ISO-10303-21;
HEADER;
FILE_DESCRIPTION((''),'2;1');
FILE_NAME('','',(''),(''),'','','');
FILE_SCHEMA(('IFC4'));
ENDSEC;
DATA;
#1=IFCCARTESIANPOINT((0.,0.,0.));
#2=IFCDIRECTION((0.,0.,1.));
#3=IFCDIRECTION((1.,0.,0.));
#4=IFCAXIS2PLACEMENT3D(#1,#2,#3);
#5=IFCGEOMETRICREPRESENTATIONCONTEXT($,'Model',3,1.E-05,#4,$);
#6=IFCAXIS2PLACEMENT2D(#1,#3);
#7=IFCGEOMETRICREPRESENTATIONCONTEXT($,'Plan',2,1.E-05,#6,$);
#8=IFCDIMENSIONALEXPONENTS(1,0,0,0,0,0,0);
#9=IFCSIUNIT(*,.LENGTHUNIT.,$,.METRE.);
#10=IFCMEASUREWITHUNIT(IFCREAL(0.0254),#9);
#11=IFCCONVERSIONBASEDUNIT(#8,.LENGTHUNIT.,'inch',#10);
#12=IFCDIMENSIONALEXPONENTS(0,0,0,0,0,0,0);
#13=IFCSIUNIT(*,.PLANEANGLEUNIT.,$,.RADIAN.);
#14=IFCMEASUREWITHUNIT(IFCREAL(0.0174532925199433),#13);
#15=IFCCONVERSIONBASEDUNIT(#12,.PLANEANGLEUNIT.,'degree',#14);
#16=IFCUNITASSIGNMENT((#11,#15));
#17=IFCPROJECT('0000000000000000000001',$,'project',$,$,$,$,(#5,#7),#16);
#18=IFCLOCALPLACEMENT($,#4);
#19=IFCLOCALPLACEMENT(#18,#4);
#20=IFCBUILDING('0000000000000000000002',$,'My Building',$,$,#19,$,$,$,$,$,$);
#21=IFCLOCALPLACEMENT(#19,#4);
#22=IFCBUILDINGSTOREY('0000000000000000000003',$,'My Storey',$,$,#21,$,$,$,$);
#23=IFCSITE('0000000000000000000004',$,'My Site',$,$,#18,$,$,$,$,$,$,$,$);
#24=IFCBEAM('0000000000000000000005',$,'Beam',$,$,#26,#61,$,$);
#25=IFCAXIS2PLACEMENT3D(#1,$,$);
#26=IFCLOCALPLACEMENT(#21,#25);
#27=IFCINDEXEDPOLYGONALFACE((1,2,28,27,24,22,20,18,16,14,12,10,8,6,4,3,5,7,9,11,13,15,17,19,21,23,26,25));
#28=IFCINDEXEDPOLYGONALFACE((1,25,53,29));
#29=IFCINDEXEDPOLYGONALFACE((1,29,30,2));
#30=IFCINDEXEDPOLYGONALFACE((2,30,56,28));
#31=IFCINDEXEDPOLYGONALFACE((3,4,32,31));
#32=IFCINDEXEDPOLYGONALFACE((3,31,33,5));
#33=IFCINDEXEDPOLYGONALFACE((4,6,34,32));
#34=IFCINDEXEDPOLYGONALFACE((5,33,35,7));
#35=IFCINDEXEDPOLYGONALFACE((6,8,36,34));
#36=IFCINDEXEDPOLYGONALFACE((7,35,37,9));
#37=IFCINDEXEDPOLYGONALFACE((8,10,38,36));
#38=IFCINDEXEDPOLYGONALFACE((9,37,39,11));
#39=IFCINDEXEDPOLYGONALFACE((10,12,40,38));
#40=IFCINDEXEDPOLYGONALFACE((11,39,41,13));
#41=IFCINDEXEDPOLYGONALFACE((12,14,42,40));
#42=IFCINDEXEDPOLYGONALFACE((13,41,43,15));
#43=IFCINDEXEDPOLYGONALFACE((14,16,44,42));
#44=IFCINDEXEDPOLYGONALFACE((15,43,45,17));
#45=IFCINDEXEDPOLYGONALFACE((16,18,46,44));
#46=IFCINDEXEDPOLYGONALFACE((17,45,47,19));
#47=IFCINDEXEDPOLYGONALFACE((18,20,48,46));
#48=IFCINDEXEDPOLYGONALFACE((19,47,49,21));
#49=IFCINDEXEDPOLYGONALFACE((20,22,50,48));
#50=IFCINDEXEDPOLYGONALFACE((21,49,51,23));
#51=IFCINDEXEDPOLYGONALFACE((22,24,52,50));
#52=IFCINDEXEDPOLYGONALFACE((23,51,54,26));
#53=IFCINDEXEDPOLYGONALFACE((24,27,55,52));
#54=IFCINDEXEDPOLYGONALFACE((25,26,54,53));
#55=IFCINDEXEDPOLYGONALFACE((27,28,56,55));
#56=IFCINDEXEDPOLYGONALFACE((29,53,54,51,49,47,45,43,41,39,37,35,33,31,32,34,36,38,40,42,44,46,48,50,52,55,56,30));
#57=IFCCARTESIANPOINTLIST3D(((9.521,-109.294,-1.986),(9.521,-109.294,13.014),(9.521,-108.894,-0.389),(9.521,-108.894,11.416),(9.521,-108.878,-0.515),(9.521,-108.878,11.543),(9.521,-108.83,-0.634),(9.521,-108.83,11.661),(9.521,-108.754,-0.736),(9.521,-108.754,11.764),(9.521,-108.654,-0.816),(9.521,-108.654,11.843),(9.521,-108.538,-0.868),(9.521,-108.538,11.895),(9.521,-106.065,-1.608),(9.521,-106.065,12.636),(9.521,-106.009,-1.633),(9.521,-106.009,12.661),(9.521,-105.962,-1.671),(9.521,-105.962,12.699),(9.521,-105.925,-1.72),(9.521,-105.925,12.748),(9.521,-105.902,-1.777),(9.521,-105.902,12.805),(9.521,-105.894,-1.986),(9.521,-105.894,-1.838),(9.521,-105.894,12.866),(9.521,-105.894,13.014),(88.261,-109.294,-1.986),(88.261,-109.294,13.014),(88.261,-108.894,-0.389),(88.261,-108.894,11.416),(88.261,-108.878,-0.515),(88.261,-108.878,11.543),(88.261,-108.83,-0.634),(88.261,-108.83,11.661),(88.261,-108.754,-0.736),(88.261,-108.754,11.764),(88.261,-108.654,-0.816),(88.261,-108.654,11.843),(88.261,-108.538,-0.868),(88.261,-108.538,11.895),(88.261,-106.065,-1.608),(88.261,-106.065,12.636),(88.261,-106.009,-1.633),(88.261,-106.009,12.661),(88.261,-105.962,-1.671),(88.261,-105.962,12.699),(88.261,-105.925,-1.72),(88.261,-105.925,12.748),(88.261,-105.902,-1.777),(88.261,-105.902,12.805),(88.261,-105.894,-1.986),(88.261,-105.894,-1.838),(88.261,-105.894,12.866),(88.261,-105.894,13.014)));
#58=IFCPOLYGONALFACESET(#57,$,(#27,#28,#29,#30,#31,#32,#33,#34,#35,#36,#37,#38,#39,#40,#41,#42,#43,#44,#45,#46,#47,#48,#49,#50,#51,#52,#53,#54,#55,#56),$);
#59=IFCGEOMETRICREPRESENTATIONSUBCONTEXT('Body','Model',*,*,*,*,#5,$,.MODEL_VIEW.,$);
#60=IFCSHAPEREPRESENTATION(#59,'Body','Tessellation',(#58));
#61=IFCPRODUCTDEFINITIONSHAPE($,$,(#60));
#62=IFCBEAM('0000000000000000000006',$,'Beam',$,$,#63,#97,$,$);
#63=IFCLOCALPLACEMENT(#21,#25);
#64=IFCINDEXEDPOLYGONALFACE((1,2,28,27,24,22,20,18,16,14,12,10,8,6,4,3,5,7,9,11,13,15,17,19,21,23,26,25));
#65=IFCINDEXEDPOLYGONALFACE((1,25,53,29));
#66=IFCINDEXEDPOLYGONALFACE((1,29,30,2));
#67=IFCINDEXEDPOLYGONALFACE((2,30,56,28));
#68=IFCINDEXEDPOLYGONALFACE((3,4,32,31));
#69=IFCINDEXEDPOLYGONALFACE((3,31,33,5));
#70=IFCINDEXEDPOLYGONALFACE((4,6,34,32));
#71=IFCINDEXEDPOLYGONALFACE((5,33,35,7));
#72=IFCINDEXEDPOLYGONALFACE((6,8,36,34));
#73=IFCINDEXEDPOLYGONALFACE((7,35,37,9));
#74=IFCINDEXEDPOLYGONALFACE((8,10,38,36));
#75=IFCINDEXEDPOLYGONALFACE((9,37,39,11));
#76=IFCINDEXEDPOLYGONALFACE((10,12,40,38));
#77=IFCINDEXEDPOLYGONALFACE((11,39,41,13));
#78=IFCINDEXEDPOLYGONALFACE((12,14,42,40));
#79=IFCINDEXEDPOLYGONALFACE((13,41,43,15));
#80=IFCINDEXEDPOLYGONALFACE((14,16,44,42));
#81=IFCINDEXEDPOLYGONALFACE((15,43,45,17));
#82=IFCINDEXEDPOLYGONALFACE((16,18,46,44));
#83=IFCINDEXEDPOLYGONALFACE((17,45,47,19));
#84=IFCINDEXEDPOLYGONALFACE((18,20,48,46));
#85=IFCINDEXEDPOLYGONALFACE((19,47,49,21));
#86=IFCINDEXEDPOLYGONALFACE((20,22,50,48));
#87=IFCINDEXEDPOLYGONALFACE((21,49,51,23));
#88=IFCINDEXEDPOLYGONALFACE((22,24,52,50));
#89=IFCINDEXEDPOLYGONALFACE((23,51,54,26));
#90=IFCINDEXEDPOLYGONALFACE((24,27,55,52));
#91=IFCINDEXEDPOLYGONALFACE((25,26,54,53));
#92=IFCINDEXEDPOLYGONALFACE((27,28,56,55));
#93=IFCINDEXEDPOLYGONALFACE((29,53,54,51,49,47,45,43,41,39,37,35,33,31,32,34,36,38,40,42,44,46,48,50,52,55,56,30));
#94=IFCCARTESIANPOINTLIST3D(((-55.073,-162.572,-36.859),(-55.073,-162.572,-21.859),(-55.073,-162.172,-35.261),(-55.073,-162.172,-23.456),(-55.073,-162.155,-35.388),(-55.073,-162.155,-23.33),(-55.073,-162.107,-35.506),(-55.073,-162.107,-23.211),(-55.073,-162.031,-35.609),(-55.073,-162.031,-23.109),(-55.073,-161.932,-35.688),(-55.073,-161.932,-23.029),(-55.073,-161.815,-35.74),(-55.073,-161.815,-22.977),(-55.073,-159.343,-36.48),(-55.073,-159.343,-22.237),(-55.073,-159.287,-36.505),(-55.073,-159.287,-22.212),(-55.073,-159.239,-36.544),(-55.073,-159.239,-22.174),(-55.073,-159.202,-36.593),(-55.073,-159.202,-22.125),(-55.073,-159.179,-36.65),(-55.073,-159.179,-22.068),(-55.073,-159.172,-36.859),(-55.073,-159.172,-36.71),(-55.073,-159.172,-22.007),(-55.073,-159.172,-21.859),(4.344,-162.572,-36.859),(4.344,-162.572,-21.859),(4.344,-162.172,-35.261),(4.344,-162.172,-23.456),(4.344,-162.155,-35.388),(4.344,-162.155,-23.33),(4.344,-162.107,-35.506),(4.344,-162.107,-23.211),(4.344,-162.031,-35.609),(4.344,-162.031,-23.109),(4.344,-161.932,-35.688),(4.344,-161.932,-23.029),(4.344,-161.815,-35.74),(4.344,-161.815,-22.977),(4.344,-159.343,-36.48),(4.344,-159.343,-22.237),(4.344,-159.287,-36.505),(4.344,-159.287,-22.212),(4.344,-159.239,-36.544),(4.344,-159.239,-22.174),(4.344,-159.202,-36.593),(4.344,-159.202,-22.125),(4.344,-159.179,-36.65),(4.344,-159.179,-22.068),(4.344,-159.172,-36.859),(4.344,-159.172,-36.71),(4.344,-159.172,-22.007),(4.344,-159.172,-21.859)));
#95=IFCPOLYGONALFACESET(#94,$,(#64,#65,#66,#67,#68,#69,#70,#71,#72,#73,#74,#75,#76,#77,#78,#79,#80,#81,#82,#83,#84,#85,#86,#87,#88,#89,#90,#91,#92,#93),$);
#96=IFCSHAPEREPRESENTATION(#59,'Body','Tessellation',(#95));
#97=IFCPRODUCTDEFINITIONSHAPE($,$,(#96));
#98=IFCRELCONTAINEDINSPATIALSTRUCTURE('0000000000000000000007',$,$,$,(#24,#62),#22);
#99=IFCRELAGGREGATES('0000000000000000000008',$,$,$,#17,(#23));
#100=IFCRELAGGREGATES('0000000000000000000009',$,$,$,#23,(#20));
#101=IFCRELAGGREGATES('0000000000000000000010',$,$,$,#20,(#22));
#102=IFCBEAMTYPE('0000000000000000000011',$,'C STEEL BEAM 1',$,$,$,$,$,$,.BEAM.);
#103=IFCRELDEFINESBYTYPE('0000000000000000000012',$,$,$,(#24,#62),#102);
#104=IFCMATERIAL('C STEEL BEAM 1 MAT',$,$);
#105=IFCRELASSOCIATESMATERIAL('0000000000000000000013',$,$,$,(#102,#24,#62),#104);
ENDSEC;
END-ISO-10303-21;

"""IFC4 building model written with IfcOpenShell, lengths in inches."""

from ifc_helpers import new_model, entity, si_unit, converted_unit, frame, frame_2d, origin_with_axes, place, context, subcontext, project, spatial, u_section, extrude, material, material_profile, profile_set, profile_usage, type_object, element, save


model = new_model("IFC4")

# Units and contexts
model_context = context("Model", 3, precision=1e-05, world=origin_with_axes())
plan_context = context("Plan", 2, precision=1e-05, world=frame_2d((0.0, 0.0, 0.0), x_axis=(1.0, 0.0, 0.0)))
body_context = subcontext(model_context, "Body", "Model", "MODEL_VIEW")
ifc_project = project(units=[converted_unit("LENGTHUNIT", "inch", entity("IfcReal", 0.0254), si_unit("LENGTHUNIT", "METRE"), dimensions=[1, 0, 0, 0, 0, 0, 0]), converted_unit("PLANEANGLEUNIT", "degree", entity("IfcReal", 0.0174532925199433), si_unit("PLANEANGLEUNIT", "RADIAN"), dimensions=[0, 0, 0, 0, 0, 0, 0])], contexts=[model_context, plan_context])

# Site, building, storey
site_placement = place(None, origin_with_axes())
site = spatial("IfcSite", under=ifc_project, at=site_placement, Name="My Site")
building_placement = place(site_placement, origin_with_axes())
building = spatial("IfcBuilding", under=site, at=building_placement, Name="My Building")
storey_placement = place(building_placement, origin_with_axes())
storey = spatial("IfcBuildingStorey", under=building, at=storey_placement, Name="My Storey")

# Beams
ifc_material = material(Name="C STEEL BEAM 1 MAT")
ifc_material_profile = material_profile(ifc_material, u_section(Depth=15.0, FlangeWidth=3.4, WebThickness=0.4, FlangeThickness=0.836, FilletRadius=0.5, EdgeRadius=0.24, FlangeSlope=16.67), Name="C STEEL BEAM 1")
ifc_profile_set = profile_set([ifc_material_profile], Name="C STEEL BEAM 1")
ifc_profile_usage_1 = profile_usage(ifc_profile_set)
beam_type = type_object("IfcBeamType", Name="C STEEL BEAM 1", PredefinedType="BEAM", material=ifc_profile_set)
beam_1_placement = place(storey_placement, frame((9.521, -107.594, 5.514), z_axis=(1.0, 0.0, 0.0), x_axis=(0.0, 1.0, 0.0)))
element("IfcBeam", 1, at=beam_1_placement, inside=storey, type_object=beam_type, material=ifc_profile_usage_1, Name="Beam", context=body_context, shape_type="SweptSolid", body=[
    extrude(u_section(Depth=15.0, FlangeWidth=3.4, WebThickness=0.4, FlangeThickness=0.836, FilletRadius=0.5, EdgeRadius=0.24, FlangeSlope=16.67), None, (0.0, 0.0, 1.0), 78.74),
])
ifc_profile_usage_2 = profile_usage(ifc_profile_set)
beam_2_placement = place(storey_placement, frame((-55.073, -160.872, -29.359), z_axis=(1.0, 0.0, 0.0), x_axis=(0.0, 1.0, 0.0)))
element("IfcBeam", 2, at=beam_2_placement, inside=storey, type_object=beam_type, material=ifc_profile_usage_2, Name="Beam", context=body_context, shape_type="SweptSolid", body=[
    extrude(u_section(Depth=15.0, FlangeWidth=3.4, WebThickness=0.4, FlangeThickness=0.836, FilletRadius=0.5, EdgeRadius=0.24, FlangeSlope=16.67), None, (0.0, 0.0, 1.0), 59.417),
])

save(model, "model.ifc")
